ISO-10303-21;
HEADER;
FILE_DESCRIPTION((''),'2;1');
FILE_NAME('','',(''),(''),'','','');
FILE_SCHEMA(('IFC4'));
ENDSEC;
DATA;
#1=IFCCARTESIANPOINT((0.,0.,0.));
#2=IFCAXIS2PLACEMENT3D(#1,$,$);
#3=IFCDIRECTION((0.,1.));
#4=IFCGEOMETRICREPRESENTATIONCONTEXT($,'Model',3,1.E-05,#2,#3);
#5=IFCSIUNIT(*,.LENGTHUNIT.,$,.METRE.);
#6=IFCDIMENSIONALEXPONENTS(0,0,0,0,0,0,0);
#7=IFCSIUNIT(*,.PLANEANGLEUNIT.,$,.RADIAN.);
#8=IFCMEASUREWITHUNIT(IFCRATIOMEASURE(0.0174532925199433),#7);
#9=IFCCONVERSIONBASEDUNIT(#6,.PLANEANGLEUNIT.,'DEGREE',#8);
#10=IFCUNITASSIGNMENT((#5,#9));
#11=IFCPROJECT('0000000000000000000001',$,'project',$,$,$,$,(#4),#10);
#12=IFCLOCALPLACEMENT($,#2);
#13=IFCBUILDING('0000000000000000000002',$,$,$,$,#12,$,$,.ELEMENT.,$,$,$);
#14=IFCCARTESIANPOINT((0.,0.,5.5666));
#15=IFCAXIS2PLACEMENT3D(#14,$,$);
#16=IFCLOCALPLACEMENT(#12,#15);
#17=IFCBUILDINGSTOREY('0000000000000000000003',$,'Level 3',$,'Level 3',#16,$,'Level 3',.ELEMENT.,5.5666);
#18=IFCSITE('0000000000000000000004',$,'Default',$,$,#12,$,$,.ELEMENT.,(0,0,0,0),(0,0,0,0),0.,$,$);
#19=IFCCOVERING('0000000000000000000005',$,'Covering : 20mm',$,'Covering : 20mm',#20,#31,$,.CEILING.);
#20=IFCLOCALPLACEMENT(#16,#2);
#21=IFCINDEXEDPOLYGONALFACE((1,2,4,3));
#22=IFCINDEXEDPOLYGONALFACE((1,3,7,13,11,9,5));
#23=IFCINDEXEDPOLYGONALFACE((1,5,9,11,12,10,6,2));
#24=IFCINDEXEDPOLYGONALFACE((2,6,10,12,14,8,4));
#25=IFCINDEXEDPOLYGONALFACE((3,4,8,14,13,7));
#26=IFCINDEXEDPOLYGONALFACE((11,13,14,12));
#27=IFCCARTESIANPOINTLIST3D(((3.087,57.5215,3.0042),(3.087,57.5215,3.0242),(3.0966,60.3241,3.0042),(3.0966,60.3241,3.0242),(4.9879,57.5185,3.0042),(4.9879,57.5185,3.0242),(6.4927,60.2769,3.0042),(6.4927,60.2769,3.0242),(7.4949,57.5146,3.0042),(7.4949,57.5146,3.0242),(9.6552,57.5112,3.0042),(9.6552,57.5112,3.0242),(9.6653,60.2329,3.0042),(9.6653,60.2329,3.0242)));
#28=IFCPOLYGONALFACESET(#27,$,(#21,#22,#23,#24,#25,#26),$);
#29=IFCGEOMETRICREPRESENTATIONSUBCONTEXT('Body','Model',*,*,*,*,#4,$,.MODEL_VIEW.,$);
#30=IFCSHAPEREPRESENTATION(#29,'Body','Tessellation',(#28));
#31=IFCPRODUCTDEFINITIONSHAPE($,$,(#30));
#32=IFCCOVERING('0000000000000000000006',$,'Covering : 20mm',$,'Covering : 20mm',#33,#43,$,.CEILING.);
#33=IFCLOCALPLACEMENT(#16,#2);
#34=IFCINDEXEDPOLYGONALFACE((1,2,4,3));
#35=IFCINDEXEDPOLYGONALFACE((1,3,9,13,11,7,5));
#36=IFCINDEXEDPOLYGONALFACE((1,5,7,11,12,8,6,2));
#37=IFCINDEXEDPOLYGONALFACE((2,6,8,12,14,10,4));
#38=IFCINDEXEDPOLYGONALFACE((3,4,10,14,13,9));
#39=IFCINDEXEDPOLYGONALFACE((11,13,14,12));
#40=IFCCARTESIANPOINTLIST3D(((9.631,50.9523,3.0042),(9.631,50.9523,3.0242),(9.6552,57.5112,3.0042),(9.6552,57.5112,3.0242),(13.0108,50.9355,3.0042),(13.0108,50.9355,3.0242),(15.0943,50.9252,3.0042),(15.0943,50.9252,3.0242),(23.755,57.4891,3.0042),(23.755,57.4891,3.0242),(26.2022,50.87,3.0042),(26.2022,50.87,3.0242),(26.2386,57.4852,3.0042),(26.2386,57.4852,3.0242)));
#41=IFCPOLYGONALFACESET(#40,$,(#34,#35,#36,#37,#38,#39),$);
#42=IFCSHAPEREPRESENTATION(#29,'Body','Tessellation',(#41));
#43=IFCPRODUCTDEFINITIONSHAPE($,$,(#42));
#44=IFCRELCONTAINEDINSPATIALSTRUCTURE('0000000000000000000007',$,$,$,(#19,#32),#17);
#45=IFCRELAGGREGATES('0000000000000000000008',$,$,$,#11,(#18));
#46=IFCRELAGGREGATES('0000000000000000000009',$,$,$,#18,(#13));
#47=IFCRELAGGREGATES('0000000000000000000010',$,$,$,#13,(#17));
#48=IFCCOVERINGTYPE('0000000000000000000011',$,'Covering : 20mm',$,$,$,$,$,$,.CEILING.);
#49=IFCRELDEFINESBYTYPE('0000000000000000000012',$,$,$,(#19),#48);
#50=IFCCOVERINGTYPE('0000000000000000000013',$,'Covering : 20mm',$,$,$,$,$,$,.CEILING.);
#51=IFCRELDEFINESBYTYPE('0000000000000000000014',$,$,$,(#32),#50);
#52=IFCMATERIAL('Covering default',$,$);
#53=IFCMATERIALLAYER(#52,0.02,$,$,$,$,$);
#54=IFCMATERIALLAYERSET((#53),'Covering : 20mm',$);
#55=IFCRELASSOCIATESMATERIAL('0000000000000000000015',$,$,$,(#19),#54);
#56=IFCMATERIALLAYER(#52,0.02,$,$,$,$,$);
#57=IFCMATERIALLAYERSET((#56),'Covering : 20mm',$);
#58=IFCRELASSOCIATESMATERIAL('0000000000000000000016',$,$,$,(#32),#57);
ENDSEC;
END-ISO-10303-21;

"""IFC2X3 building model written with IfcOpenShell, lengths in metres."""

from ifc_helpers import new_model, entity, si_unit, converted_unit, direction, frame, origin, origin_with_axes, place, context, subcontext, project, spatial, polyline, outline, extrude, material, layer, layer_set, layer_usage, type_object, element, save


model = new_model("IFC2X3")

# Units and contexts
model_context = context("Model", 3, precision=1e-05, world=origin(), true_north=direction((0.0, 1.0)))
body_context = subcontext(model_context, "Body", "Model", "MODEL_VIEW")
ifc_project = project(units=[si_unit("LENGTHUNIT", "METRE"), converted_unit("PLANEANGLEUNIT", "DEGREE", entity("IfcRatioMeasure", 0.0174532925199433), si_unit("PLANEANGLEUNIT", "RADIAN"), dimensions=[0, 0, 0, 0, 0, 0, 0])], contexts=[model_context])

# Site, building, storey
placement_1 = place(None, origin())
site = spatial("IfcSite", under=ifc_project, at=placement_1, Name="Default", CompositionType="ELEMENT", RefLatitude=(0, 0, 0, 0), RefLongitude=(0, 0, 0, 0), RefElevation=0.0)
building = spatial("IfcBuilding", under=site, at=placement_1, CompositionType="ELEMENT")
storey_placement = place(placement_1, frame((0.0, 0.0, 5.5666)))
storey = spatial("IfcBuildingStorey", under=building, at=storey_placement, Name="Level 3", ObjectType="Level 3", LongName="Level 3", CompositionType="ELEMENT", Elevation=5.5666)

# Coverings
ifc_material_1 = material(Name="Covering default")
ifc_layer_1 = layer(ifc_material_1, 0.02)
ifc_layer_set_1 = layer_set([ifc_layer_1], Name="Covering : 20mm")
ifc_layer_usage_1 = layer_usage(ifc_layer_set_1, "AXIS3", "POSITIVE", 0.0)
covering_type_1 = type_object("IfcCoveringType", Name="Covering : 20mm", PredefinedType="CEILING")
covering_1_placement = place(placement_1, frame((0.0, 0.0, 8.5708)))
element("IfcCovering", 1, at=covering_1_placement, inside=storey, type_object=covering_type_1, material=ifc_layer_usage_1, Name="Covering : 20mm", ObjectType="Covering : 20mm", PredefinedType="CEILING", context=body_context, shape_type="SweptSolid", body=[
    extrude(outline(polyline([(6.4927, 60.2769), (3.0966, 60.3241), (3.087, 57.5215), (4.9879, 57.5185), (7.4949, 57.5146), (9.6552, 57.5112), (9.6653, 60.2329), (6.4927, 60.2769)])), origin_with_axes(), (0.0, 0.0, 1.0), 0.02),
])
ifc_layer_2 = layer(ifc_material_1, 0.02)
ifc_layer_set_2 = layer_set([ifc_layer_2], Name="Covering : 20mm")
ifc_layer_usage_2 = layer_usage(ifc_layer_set_2, "AXIS3", "POSITIVE", 0.0)
covering_type_2 = type_object("IfcCoveringType", Name="Covering : 20mm", PredefinedType="CEILING")
covering_2_placement = place(placement_1, frame((0.0, 0.0, 8.5708)))
element("IfcCovering", 2, at=covering_2_placement, inside=storey, type_object=covering_type_2, material=ifc_layer_usage_2, Name="Covering : 20mm", ObjectType="Covering : 20mm", PredefinedType="CEILING", context=body_context, shape_type="SweptSolid", body=[
    extrude(outline(polyline([(9.631, 50.9523), (13.0108, 50.9355), (15.0943, 50.9252), (26.2022, 50.87), (26.2386, 57.4852), (23.755, 57.4891), (9.6552, 57.5112), (9.631, 50.9523)])), origin_with_axes(), (0.0, 0.0, 1.0), 0.02),
])

save(model, "model.ifc")
